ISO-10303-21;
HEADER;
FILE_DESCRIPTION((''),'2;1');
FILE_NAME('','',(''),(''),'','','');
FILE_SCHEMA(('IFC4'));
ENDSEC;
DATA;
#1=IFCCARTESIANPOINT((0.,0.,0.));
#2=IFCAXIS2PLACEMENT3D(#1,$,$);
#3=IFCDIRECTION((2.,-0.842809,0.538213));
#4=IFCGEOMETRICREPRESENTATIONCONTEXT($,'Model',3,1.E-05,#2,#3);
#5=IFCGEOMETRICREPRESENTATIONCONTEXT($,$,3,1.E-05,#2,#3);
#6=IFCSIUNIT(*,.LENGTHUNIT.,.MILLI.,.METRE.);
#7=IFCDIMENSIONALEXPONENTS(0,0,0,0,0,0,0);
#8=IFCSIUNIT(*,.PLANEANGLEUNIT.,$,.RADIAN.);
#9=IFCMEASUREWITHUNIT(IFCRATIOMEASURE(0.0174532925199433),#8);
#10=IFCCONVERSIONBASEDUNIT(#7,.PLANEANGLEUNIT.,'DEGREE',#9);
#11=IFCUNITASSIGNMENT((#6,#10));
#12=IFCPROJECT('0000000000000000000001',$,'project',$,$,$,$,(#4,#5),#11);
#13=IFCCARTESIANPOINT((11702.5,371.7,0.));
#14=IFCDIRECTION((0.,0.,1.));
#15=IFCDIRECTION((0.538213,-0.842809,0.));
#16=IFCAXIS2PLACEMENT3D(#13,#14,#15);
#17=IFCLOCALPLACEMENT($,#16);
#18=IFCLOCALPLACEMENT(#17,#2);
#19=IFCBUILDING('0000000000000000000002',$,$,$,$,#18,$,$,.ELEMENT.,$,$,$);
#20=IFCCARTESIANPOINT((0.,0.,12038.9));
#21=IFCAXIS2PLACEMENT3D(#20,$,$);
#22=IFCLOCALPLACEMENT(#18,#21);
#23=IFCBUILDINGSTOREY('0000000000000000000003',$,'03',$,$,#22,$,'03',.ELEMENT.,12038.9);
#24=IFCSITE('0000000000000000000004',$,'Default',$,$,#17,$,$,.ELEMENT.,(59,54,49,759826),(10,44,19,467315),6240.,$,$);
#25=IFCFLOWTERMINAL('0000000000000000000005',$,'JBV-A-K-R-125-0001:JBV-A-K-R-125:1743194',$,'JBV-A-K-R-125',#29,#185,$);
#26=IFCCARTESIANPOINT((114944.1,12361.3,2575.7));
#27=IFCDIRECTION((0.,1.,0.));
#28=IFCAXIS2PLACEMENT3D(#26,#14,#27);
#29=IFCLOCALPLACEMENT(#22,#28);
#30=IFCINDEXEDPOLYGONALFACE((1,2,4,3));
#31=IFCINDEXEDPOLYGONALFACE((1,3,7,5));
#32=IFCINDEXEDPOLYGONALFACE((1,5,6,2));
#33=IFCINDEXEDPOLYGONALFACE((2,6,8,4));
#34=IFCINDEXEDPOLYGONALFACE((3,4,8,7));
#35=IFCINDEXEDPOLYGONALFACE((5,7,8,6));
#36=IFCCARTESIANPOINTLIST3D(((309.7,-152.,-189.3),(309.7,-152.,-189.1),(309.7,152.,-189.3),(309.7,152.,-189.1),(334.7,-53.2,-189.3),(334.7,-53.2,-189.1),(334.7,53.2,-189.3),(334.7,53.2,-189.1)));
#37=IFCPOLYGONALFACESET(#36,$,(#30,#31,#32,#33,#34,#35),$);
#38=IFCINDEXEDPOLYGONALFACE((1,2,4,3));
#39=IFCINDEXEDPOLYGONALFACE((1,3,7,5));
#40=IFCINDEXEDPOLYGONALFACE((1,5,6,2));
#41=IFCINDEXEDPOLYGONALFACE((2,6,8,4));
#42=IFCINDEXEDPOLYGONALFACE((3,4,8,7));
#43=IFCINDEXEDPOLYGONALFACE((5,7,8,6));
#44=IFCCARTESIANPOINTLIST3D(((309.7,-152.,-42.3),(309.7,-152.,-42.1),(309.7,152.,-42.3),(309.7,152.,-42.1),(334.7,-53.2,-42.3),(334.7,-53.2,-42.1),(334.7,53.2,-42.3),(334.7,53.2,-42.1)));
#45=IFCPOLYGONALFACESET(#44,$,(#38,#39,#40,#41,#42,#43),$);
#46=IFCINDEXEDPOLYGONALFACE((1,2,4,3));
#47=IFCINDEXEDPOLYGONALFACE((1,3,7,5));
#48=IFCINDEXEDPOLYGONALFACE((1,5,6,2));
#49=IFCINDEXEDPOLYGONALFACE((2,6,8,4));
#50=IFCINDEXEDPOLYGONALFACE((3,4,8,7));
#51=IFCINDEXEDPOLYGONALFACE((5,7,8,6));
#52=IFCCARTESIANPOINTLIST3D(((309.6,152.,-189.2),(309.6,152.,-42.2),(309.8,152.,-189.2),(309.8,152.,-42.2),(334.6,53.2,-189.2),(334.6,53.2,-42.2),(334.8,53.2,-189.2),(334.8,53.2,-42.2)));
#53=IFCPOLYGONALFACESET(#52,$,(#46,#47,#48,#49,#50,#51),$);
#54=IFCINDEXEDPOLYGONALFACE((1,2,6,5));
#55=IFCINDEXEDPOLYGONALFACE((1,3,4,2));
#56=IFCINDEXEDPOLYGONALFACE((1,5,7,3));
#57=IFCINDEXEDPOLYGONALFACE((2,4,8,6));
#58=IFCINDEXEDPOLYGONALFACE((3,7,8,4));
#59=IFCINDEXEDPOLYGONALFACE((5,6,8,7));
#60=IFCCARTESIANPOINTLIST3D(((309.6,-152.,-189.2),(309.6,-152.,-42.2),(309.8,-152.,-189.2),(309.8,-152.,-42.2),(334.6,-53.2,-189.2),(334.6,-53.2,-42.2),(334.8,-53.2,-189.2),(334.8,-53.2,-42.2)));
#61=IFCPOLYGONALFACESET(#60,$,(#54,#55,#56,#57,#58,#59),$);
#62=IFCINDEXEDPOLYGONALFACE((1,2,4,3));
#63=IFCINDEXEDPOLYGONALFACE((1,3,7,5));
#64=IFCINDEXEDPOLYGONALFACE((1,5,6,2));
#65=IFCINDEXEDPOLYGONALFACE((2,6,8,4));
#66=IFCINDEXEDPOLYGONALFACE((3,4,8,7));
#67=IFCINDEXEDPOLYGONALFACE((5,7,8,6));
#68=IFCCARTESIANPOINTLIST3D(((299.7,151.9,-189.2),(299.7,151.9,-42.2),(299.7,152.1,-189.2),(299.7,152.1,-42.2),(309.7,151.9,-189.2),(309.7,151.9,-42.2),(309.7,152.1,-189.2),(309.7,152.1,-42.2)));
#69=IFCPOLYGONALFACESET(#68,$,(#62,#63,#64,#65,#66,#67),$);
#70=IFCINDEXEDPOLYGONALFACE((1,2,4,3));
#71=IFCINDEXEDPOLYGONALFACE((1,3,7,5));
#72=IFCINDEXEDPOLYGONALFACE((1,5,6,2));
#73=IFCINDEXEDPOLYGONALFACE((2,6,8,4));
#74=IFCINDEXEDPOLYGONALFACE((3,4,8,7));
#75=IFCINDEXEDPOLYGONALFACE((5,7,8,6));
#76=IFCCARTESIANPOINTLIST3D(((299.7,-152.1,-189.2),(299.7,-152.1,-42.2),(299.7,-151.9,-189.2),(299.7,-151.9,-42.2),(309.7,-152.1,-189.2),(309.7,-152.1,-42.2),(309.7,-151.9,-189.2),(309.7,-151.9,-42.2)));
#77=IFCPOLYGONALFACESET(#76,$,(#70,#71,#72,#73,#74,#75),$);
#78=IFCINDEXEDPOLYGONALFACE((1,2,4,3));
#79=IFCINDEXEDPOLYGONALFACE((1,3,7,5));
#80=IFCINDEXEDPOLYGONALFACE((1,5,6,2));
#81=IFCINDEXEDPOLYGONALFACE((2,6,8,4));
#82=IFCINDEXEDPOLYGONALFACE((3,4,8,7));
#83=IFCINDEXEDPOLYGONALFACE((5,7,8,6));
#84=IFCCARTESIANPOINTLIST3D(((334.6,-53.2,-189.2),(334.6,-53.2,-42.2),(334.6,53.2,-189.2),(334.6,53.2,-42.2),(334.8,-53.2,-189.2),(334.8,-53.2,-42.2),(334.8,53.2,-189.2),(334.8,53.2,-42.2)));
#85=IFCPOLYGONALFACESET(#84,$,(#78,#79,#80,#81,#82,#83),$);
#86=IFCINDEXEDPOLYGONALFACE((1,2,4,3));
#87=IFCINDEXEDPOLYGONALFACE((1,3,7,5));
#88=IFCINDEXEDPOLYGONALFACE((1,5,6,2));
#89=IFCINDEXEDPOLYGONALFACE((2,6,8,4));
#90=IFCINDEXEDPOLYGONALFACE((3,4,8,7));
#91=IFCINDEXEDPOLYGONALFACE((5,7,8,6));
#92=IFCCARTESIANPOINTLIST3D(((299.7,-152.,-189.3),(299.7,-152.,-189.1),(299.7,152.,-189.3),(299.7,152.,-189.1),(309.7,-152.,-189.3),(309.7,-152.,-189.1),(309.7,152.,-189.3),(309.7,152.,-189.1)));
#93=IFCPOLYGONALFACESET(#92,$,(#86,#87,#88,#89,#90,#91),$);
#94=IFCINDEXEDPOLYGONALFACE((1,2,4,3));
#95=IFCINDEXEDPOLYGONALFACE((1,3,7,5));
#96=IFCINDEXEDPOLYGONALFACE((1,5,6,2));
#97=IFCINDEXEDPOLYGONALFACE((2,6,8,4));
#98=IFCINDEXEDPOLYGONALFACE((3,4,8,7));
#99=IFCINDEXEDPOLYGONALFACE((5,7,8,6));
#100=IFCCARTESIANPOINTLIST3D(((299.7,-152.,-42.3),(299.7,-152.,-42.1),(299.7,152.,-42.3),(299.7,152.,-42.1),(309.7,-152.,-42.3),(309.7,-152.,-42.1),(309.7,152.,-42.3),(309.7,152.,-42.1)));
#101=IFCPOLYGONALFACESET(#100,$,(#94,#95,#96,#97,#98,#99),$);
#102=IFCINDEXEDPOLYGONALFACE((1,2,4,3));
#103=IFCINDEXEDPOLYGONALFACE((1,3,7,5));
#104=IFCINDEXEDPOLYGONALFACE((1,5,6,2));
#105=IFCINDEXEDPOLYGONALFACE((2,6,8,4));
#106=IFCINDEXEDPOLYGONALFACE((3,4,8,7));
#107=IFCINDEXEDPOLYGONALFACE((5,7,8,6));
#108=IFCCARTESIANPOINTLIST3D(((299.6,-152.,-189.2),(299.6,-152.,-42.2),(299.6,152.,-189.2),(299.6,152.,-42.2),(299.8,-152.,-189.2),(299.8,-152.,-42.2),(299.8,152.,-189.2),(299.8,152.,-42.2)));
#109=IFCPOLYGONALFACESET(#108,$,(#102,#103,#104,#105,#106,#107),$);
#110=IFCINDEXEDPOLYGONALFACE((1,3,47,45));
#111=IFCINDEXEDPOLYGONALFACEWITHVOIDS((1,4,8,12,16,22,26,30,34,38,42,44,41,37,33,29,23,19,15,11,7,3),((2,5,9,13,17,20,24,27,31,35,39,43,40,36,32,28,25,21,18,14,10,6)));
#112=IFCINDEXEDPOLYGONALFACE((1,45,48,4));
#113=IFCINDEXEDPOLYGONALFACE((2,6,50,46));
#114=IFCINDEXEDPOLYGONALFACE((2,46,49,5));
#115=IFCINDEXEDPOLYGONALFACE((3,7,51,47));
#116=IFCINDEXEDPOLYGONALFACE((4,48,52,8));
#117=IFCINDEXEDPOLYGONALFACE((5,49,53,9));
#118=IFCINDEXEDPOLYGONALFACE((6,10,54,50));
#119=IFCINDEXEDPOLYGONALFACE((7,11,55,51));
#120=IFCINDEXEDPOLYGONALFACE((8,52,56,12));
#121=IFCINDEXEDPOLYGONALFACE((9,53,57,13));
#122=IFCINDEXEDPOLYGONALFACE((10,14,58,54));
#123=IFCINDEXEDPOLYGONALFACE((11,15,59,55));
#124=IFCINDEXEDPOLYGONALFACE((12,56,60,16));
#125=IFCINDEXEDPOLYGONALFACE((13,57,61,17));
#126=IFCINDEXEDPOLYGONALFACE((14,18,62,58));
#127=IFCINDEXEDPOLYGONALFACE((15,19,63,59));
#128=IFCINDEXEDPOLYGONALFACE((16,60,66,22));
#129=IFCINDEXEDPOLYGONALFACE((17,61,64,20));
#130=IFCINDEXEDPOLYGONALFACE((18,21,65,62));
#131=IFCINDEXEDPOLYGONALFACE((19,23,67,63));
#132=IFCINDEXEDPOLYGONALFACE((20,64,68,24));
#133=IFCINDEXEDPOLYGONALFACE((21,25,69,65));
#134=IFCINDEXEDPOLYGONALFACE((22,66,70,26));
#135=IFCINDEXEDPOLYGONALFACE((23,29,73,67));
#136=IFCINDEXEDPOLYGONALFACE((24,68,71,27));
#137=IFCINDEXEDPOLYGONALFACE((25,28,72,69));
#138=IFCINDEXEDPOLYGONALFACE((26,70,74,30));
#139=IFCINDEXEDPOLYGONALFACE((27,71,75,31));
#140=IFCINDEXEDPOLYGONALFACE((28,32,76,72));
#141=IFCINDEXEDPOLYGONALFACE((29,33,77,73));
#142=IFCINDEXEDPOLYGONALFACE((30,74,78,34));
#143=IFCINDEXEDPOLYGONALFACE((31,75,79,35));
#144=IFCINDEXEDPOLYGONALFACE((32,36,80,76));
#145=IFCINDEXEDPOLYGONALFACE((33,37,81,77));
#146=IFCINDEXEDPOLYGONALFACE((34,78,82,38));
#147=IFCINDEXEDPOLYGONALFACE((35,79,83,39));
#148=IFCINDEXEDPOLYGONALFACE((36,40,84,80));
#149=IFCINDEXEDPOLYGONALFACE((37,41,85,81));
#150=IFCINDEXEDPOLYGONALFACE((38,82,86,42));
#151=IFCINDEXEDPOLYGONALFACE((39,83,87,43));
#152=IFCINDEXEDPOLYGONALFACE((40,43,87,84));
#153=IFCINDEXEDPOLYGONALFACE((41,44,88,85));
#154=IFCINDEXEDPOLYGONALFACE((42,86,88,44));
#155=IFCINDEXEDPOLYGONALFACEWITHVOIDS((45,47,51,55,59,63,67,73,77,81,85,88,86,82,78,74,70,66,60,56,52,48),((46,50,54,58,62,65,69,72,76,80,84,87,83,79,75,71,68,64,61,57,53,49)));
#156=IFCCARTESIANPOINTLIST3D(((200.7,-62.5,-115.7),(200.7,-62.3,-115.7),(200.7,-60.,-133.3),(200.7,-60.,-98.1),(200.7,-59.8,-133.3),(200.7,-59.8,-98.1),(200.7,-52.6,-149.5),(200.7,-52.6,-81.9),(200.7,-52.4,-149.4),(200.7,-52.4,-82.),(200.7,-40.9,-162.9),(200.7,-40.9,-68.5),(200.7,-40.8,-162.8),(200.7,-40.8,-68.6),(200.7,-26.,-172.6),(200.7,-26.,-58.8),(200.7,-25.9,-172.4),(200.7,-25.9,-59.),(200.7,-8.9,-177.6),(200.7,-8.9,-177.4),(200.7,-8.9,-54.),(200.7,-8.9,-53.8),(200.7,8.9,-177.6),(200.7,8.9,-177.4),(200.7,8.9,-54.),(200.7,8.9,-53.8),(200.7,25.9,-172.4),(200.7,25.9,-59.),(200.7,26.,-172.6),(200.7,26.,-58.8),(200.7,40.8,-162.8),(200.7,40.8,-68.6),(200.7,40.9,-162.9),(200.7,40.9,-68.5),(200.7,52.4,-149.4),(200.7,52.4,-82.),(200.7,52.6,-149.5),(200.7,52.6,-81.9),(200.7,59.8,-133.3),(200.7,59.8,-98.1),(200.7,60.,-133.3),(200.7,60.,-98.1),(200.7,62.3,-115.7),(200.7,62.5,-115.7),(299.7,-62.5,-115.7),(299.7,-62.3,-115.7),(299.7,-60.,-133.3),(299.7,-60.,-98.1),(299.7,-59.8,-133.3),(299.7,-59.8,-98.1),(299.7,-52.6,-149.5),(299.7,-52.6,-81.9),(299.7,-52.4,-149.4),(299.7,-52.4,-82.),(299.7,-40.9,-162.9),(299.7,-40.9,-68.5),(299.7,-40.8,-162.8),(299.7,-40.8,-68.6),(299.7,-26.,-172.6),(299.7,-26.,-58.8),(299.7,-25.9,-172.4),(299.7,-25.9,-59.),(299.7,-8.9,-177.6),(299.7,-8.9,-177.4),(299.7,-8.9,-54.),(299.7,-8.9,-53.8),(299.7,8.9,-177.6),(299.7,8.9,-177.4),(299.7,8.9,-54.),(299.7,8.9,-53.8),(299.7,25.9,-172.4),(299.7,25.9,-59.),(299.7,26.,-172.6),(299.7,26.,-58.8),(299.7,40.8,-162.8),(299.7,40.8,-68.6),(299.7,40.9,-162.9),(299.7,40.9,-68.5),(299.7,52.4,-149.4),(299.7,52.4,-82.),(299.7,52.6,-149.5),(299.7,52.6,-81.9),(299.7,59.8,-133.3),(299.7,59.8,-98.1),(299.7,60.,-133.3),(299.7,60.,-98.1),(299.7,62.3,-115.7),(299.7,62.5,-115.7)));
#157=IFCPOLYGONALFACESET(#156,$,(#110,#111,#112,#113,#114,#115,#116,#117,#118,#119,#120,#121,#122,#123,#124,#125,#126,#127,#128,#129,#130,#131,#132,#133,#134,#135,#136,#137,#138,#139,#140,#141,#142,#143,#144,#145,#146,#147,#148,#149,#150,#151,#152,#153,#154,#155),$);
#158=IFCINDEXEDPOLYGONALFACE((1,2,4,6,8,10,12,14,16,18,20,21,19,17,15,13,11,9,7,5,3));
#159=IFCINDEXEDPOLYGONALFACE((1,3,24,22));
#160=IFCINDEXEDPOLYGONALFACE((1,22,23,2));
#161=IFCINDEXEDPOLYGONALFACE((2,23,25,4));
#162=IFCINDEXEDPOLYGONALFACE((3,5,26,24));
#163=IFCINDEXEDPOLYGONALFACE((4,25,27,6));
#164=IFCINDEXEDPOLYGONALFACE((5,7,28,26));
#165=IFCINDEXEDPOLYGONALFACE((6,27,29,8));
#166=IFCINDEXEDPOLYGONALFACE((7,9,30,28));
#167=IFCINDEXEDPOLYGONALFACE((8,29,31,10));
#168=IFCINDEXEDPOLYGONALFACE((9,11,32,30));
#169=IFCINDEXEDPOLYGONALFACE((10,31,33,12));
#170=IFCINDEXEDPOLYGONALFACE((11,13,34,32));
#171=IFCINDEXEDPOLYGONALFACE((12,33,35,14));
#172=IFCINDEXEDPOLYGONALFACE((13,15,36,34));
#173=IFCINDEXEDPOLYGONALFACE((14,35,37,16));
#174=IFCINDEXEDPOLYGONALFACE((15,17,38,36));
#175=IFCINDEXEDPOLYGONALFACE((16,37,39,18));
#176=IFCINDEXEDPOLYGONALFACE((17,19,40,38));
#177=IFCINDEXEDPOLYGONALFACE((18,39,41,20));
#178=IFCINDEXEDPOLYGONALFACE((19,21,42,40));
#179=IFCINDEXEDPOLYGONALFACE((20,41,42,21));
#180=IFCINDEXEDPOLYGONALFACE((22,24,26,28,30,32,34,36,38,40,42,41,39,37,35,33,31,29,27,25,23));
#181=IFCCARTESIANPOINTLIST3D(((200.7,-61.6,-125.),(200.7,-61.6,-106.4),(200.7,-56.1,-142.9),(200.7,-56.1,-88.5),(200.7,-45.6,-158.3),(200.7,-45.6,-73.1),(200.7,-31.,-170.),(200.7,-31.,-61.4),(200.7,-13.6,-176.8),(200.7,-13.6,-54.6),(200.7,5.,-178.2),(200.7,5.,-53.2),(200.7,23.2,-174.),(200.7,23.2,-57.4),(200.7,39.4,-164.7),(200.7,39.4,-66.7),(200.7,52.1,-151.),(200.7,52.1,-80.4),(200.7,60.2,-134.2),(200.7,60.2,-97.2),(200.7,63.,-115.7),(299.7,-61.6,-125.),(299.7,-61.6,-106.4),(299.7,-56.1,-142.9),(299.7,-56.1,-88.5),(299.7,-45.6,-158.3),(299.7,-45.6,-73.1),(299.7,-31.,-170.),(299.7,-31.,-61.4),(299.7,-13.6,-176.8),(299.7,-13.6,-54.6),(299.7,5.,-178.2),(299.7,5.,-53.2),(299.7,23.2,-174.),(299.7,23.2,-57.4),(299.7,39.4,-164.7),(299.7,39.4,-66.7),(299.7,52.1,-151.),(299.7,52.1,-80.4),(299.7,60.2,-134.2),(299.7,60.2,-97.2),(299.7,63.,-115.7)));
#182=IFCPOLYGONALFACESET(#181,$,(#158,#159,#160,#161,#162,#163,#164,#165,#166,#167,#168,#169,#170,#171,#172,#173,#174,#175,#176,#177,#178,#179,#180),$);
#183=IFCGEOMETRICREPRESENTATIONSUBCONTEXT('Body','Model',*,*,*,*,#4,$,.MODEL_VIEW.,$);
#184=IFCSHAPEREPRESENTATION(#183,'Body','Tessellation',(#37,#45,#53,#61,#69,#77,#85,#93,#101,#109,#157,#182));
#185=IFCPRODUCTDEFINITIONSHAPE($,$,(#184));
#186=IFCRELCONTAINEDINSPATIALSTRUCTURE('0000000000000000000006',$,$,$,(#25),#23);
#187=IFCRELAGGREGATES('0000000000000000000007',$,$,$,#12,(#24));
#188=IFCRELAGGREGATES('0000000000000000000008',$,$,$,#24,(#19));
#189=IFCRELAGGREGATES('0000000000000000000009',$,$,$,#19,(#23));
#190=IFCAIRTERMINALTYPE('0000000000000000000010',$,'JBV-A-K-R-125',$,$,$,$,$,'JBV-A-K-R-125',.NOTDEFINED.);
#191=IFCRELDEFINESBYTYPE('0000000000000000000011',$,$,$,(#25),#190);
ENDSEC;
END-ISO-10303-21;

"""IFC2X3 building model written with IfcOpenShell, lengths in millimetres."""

from ifc_helpers import new_model, entity, si_unit, converted_unit, direction, frame, frame_2d, origin, origin_2d_with_axis, place, context, subcontext, project, spatial, polyline, circle_curve, parameter, trimmed, segment, composite_curve, rectangle, circle, outline, extrude, source, transform, mapped, type_object, type_shapes, element, save


model = new_model("IFC2X3")

# Units and contexts
model_context = context("Model", 3, precision=1e-05, world=origin(), true_north=direction((2.0, -0.842809, 0.538213)))
context_of_model = context(None, 3, precision=1e-05, world=origin(), true_north=direction((2.0, -0.842809, 0.538213)))
body_context = subcontext(model_context, "Body", "Model", "MODEL_VIEW")
ifc_project = project(units=[si_unit("LENGTHUNIT", "METRE", prefix="MILLI"), converted_unit("PLANEANGLEUNIT", "DEGREE", entity("IfcRatioMeasure", 0.0174532925199433), si_unit("PLANEANGLEUNIT", "RADIAN"), dimensions=[0, 0, 0, 0, 0, 0, 0])], contexts=[model_context, context_of_model])

# Site, building, storey
site_placement = place(None, frame((11702.5, 371.7, 0.0), z_axis=(0.0, 0.0, 1.0), x_axis=(0.538213, -0.842809, 0.0)))
site = spatial("IfcSite", under=ifc_project, at=site_placement, Name="Default", CompositionType="ELEMENT", RefLatitude=(59, 54, 49, 759826), RefLongitude=(10, 44, 19, 467315), RefElevation=6240.0)
building_placement = place(site_placement, origin())
building = spatial("IfcBuilding", under=site, at=building_placement, CompositionType="ELEMENT")
storey_placement = place(building_placement, frame((0.0, 0.0, 12038.9)))
storey = spatial("IfcBuildingStorey", under=building, at=storey_placement, Name="03", LongName="03", CompositionType="ELEMENT", Elevation=12038.9)

# Flow terminal
air_terminal_type_1 = type_object("IfcAirTerminalType", Name="JBV-A-K-R-125", ElementType="JBV-A-K-R-125", PredefinedType="NOTDEFINED")
shared_shape_1 = source(origin(), body_context, "Body", "SweptSolid", [
    extrude(outline(polyline([(-152.0, -12.5), (152.0, -12.5), (53.2, 12.5), (-53.2, 12.5), (-152.0, -12.5)])), frame((322.2, 0.0, -189.3), z_axis=(0.0, 0.0, 1.0), x_axis=(0.0, -1.0, 0.0)), (0.0, 0.0, 1.0), 0.2),
    extrude(outline(polyline([(-152.0, -12.5), (152.0, -12.5), (53.2, 12.5), (-53.2, 12.5), (-152.0, -12.5)])), frame((322.2, 0.0, -42.3), z_axis=(0.0, 0.0, 1.0), x_axis=(0.0, -1.0, 0.0)), (0.0, 0.0, 1.0), 0.2),
    extrude(rectangle(XDim=0.2, YDim=101.9, at=frame_2d((0.0, 0.0), x_axis=(1.0, 0.0))), frame((322.2, 102.6, -189.2), z_axis=(0.0, 0.0, 1.0), x_axis=(0.969446, 0.245305, 0.0)), (0.0, 0.0, 1.0), 147.0),
    extrude(rectangle(XDim=0.2, YDim=101.9, at=frame_2d((0.0, 0.0), x_axis=(1.0, 0.0))), frame((322.2, -102.6, -189.2), z_axis=(0.0, 0.0, 1.0), x_axis=(-0.969446, 0.245305, 0.0)), (0.0, 0.0, 1.0), 147.0),
    extrude(rectangle(XDim=0.2, YDim=10.0, at=frame_2d((0.0, 0.0), x_axis=(1.0, 0.0))), frame((304.7, 152.0, -189.2), z_axis=(0.0, 0.0, 1.0), x_axis=(0.0, 1.0, 0.0)), (0.0, 0.0, 1.0), 147.0),
    extrude(rectangle(XDim=0.2, YDim=10.0, at=frame_2d((0.0, 0.0), x_axis=(1.0, 0.0))), frame((304.7, -152.0, -189.2), z_axis=(0.0, 0.0, 1.0), x_axis=(0.0, 1.0, 0.0)), (0.0, 0.0, 1.0), 147.0),
    extrude(rectangle(XDim=0.2, YDim=106.4, at=frame_2d((0.0, 0.0), x_axis=(1.0, 0.0))), frame((334.7, 0.0, -189.2)), (0.0, 0.0, 1.0), 147.0),
    extrude(rectangle(XDim=304.0, YDim=10.0, at=frame_2d((0.0, 0.0), x_axis=(1.0, 0.0))), frame((304.7, 0.0, -189.3), z_axis=(0.0, 0.0, 1.0), x_axis=(0.0, -1.0, 0.0)), (0.0, 0.0, 1.0), 0.2),
    extrude(rectangle(XDim=304.0, YDim=10.0, at=frame_2d((0.0, 0.0), x_axis=(1.0, 0.0))), frame((304.7, 0.0, -42.3), z_axis=(0.0, 0.0, 1.0), x_axis=(0.0, -1.0, 0.0)), (0.0, 0.0, 1.0), 0.2),
    extrude(rectangle(XDim=0.2, YDim=304.0, at=frame_2d((0.0, 0.0), x_axis=(1.0, 0.0))), frame((299.7, 0.0, -189.2)), (0.0, 0.0, 1.0), 147.0),
    extrude(outline(composite_curve([segment(trimmed(circle_curve(origin_2d_with_axis(), 62.5), [parameter(0.0)], [parameter(180.0)], True, "PARAMETER"), True, "CONTINUOUS"), segment(trimmed(circle_curve(origin_2d_with_axis(), 62.5), [parameter(180.0)], [parameter(360.0)], True, "PARAMETER"), True, "CONTINUOUS")], self_intersect=False), holes=[composite_curve([segment(trimmed(circle_curve(origin_2d_with_axis(), 62.3), [parameter(180.0)], [parameter(360.0)], True, "PARAMETER"), False, "CONTINUOUS"), segment(trimmed(circle_curve(origin_2d_with_axis(), 62.3), [parameter(0.0)], [parameter(180.0)], True, "PARAMETER"), False, "CONTINUOUS")], self_intersect=False)]), frame((200.7, 0.0, -115.7), z_axis=(1.0, 0.0, 0.0), x_axis=(0.0, 1.0, 0.0)), (0.0, 0.0, 1.0), 99.0),
    extrude(circle(Radius=62.6, at=frame_2d((0.0, 0.0), x_axis=(1.0, 0.0))), frame((200.7, 0.3, -115.7), z_axis=(1.0, 0.0, 0.0), x_axis=(0.0, 1.0, 0.0)), (0.0, 0.0, 1.0), 99.0),
])
type_shapes(air_terminal_type_1, [shared_shape_1])
for number, where, z_axis, x_axis, name in (
    (1, (114944.1, 12361.3, 2575.7), (0.0, 0.0, 1.0), (0.0, 1.0, 0.0), "JBV-A-K-R-125-0001:JBV-A-K-R-125:1743194"),
):
    element("IfcFlowTerminal", number, at=place(storey_placement, frame(where, z_axis=z_axis, x_axis=x_axis)), inside=storey, type_object=air_terminal_type_1, Name=name, ObjectType="JBV-A-K-R-125", context=body_context, shape_type="MappedRepresentation", body=[
        mapped(shared_shape_1, transform((0.0, 0.0, 0.0), scale=1.0)),
    ])

save(model, "model.ifc")
